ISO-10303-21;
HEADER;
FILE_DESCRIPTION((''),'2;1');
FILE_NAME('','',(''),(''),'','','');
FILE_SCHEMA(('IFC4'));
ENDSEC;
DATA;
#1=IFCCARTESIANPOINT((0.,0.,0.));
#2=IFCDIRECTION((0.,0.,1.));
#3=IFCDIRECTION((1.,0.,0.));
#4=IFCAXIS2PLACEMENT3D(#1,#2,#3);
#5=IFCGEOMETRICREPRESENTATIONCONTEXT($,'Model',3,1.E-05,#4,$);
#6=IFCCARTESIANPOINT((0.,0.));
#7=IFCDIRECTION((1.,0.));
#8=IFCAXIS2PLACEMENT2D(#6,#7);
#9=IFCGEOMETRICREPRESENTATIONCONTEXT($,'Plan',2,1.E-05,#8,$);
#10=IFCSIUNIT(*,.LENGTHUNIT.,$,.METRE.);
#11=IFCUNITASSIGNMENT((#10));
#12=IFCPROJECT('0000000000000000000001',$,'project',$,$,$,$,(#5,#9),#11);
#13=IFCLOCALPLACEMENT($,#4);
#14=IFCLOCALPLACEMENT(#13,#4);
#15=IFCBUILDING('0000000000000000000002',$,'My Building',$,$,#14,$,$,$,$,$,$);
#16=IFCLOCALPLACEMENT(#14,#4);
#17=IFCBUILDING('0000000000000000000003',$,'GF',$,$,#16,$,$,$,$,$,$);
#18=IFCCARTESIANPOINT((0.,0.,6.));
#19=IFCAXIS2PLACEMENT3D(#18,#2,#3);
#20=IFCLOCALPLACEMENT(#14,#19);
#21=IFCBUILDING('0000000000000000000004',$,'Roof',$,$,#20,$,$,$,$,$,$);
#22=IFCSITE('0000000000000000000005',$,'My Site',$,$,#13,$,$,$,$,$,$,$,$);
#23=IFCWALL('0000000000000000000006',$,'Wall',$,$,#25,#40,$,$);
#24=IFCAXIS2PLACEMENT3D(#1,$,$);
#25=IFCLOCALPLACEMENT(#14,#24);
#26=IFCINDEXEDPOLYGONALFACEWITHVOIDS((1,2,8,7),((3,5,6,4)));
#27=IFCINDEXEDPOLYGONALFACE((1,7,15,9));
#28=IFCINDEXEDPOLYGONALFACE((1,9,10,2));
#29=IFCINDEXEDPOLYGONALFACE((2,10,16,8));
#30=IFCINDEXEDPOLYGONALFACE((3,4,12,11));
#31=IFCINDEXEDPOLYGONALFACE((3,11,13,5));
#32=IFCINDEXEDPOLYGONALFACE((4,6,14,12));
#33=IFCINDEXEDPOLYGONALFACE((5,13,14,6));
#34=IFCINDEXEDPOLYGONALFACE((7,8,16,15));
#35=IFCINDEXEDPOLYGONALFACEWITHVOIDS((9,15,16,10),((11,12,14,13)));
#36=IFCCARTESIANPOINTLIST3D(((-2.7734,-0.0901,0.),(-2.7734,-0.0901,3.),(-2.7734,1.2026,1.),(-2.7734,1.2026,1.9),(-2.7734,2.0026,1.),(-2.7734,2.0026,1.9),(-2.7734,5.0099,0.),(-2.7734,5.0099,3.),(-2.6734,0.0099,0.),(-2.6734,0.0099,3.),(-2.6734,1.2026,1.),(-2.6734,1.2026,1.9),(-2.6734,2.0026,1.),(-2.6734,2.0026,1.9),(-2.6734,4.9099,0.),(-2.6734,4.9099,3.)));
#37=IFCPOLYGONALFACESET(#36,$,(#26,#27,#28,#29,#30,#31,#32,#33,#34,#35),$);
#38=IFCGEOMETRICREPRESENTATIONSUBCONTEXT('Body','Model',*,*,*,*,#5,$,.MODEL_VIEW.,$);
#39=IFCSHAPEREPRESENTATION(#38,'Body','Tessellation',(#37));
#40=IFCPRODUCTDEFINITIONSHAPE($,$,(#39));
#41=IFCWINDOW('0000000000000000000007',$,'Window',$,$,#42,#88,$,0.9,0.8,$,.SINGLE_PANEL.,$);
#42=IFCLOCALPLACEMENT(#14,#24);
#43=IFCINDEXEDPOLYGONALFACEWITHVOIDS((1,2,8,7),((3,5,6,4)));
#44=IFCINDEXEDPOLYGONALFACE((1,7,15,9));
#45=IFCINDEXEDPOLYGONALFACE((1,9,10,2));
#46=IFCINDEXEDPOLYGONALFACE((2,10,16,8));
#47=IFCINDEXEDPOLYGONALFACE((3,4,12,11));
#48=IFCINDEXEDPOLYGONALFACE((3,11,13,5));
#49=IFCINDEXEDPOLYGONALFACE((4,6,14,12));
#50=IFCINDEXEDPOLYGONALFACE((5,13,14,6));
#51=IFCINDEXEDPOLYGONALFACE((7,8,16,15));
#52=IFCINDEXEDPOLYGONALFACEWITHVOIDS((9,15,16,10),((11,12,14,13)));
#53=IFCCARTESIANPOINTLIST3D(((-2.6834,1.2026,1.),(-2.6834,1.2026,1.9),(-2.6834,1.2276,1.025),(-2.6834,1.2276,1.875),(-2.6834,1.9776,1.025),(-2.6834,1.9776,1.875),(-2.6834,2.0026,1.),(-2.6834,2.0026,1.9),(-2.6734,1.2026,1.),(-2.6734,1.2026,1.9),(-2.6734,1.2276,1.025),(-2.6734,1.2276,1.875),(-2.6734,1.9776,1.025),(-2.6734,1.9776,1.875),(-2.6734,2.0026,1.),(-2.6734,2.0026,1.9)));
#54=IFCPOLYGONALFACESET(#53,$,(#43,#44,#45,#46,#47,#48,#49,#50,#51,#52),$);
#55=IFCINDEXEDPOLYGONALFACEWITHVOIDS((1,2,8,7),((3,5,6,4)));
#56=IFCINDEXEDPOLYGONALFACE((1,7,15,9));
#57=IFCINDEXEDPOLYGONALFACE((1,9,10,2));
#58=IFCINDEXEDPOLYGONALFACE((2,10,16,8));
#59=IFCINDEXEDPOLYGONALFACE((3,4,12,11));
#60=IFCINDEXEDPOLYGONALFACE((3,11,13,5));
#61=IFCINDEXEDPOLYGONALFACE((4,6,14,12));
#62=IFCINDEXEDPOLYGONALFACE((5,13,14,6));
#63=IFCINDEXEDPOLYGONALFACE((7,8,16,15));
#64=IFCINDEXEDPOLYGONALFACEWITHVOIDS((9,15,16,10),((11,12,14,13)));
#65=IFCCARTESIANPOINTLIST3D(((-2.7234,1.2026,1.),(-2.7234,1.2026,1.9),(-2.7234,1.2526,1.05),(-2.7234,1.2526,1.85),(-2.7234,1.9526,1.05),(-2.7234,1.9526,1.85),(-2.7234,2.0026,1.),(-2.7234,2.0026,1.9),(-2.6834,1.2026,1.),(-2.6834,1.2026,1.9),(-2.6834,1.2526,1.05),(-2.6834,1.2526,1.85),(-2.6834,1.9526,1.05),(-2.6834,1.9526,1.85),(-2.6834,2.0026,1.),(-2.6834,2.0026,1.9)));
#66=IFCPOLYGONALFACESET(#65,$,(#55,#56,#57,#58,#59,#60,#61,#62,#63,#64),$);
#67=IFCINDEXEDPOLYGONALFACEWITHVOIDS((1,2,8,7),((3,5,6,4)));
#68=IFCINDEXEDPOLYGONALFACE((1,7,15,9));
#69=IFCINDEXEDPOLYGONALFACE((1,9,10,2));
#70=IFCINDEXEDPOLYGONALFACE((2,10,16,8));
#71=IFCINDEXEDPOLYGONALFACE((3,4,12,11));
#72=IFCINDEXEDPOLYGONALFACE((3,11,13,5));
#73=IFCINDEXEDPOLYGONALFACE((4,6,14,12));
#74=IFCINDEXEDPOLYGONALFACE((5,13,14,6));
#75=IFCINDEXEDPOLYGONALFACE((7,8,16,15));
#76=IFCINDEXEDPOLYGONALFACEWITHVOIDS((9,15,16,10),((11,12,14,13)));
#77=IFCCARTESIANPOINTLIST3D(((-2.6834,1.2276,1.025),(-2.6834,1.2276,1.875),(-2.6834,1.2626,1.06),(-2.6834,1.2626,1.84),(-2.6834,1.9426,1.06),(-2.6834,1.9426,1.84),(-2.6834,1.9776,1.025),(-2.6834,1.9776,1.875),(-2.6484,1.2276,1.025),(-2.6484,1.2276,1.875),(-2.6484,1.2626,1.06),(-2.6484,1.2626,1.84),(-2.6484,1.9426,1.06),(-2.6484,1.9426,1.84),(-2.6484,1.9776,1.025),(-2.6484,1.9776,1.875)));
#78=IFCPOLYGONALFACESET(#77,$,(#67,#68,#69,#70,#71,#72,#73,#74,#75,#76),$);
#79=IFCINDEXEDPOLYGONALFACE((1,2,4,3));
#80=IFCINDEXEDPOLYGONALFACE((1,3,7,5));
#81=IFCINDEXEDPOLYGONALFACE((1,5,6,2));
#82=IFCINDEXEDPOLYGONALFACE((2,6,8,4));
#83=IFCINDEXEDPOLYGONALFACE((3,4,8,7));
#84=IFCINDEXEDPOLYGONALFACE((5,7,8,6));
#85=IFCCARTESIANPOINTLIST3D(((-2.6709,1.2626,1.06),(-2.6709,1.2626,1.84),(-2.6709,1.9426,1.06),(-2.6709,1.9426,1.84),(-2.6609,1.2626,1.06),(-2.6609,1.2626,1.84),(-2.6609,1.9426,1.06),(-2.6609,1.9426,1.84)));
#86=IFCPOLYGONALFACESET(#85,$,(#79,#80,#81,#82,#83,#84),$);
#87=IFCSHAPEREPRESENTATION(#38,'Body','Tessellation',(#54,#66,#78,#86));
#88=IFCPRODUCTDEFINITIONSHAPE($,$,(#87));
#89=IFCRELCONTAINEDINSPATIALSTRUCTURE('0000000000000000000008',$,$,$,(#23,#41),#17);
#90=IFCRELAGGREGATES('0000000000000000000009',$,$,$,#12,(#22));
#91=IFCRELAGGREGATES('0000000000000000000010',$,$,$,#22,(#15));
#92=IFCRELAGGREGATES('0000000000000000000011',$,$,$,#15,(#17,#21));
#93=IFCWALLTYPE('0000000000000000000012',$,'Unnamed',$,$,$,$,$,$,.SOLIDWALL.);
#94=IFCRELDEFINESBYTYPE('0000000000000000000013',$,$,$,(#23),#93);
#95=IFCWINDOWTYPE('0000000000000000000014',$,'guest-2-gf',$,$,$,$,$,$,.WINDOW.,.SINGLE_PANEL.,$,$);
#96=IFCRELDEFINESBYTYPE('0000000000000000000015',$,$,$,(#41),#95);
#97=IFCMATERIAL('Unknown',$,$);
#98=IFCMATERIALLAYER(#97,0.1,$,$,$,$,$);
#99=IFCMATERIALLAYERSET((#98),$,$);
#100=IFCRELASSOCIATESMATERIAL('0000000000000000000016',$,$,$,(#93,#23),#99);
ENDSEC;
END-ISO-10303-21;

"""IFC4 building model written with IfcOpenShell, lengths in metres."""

from ifc_helpers import new_model, entity, si_unit, frame, origin_with_axes, origin_2d_with_axis, place, context, subcontext, project, spatial, line, indexed_curve, outline, extrude, shape, source, transform, mapped, material, layer, layer_set, layer_usage, type_object, type_shapes, element, fill, save


model = new_model("IFC4")

# Units and contexts
model_context = context("Model", 3, precision=1e-05, world=origin_with_axes())
plan_context = context("Plan", 2, precision=1e-05, world=origin_2d_with_axis())
body_context_1 = subcontext(model_context, "Body", "Model", "MODEL_VIEW")
body_context_2 = subcontext(plan_context, "Body", "Plan", "PLAN_VIEW")
ifc_project = project(units=[si_unit("LENGTHUNIT", "METRE")], contexts=[model_context, plan_context])

# Site, buildings
site_placement = place(None, origin_with_axes())
site = spatial("IfcSite", under=ifc_project, at=site_placement, Name="My Site")
building_1_placement = place(site_placement, origin_with_axes())
building_1 = spatial("IfcBuilding", under=site, at=building_1_placement, Name="My Building")
building_2_placement = place(building_1_placement, origin_with_axes())
building_2 = spatial("IfcBuilding", under=building_1, at=building_2_placement, Name="GF")

# Shared definitions
ifc_material = material(Name="Unknown")

# Shared definitions
building_3_placement = place(building_1_placement, frame((0.0, 0.0, 6.0), z_axis=(0.0, 0.0, 1.0), x_axis=(1.0, 0.0, 0.0)))
building_3 = spatial("IfcBuilding", under=building_1, at=building_3_placement, Name="Roof")

# Shared definitions
ifc_layer_1 = layer(ifc_material, 0.1)
ifc_layer_set_1 = layer_set([ifc_layer_1])
wall_type = type_object("IfcWallType", Name="Unnamed", PredefinedType="SOLIDWALL", material=ifc_layer_set_1)

# Wall, opening, window
ifc_layer_usage_1 = layer_usage(ifc_layer_set_1, "AXIS2", "POSITIVE", 0.0)
wall_1_placement = place(building_2_placement, frame((-2.7734, 5.0099, 0.0), z_axis=(0.0, 0.0, 1.0), x_axis=(0.0, -1.0, 0.0)))
wall_1 = element("IfcWall", 1, at=wall_1_placement, inside=building_2, type_object=wall_type, material=ifc_layer_usage_1, Name="Wall", context=body_context_1, shape_type="SweptSolid", body=[
    extrude(outline(indexed_curve([(0.0, 0.0), (0.1, 0.1), (5.0, 0.1), (5.1, 0.0)], segments=[line(1, 2, 3, 4, 1)])), origin_with_axes(), (0.0, 0.0, 1.0), 3.0),
])
shared_shape_1 = source(origin_with_axes(), body_context_1, "Body", "SweptSolid", [
    extrude(outline(indexed_curve([(0.0, 0.0), (0.8, 0.0), (0.8, 0.9), (0.0, 0.9)], segments=[line(1, 2, 3, 4, 1)])), frame((0.0, -0.6, 0.0), z_axis=(0.0, -1.0, 0.0), x_axis=(1.0, 0.0, 0.0)), (0.0, 0.0, -1.0), 1.2),
])
opening_1_placement = place(wall_1_placement, frame((3.0073, 0.0, 1.0), z_axis=(0.0, 0.0, 1.0), x_axis=(1.0, 0.0, 0.0)))
opening_1 = element("IfcOpeningElement", 2, at=opening_1_placement, cuts=wall_1, PredefinedType="OPENING", context=body_context_1, shape_type="MappedRepresentation", body=[
    mapped(shared_shape_1, transform((0.0, 0.0, 0.0), x_axis=(1.0, 0.0, 0.0), y_axis=(0.0, 1.0, 0.0), z_axis=(0.0, 0.0, 1.0), scale=1.0)),
])
window_type_1 = type_object("IfcWindowType", Name="guest-2-gf", PartitioningType="SINGLE_PANEL", PredefinedType="WINDOW")
shared_shape_2 = source(origin_with_axes(), body_context_1, "Body", "SweptSolid", [
    extrude(outline(indexed_curve([(0.0, 0.0), (0.8, 0.0), (0.8, 0.9), (0.0, 0.9)], segments=[line(1, 2, 3, 4, 1)]), holes=[indexed_curve([(0.025, 0.025), (0.775, 0.025), (0.775, 0.875), (0.025, 0.875)], segments=[line(1, 2, 3, 4, 1)])]), frame((0.0, 0.09, 0.0), z_axis=(0.0, -1.0, 0.0), x_axis=(1.0, 0.0, 0.0)), (0.0, 0.0, -1.0), 0.01),
    extrude(outline(indexed_curve([(0.0, 0.0), (0.8, 0.0), (0.8, 0.9), (0.0, 0.9)], segments=[line(1, 2, 3, 4, 1)]), holes=[indexed_curve([(0.05, 0.05), (0.75, 0.05), (0.75, 0.85), (0.05, 0.85)], segments=[line(1, 2, 3, 4, 1)])]), frame((0.0, 0.05, 0.0), z_axis=(0.0, -1.0, 0.0), x_axis=(1.0, 0.0, 0.0)), (0.0, 0.0, -1.0), 0.04),
    extrude(outline(indexed_curve([(0.0, 0.0), (0.75, 0.0), (0.75, 0.85), (0.0, 0.85)], segments=[line(1, 2, 3, 4, 1)]), holes=[indexed_curve([(0.035, 0.035), (0.715, 0.035), (0.715, 0.815), (0.035, 0.815)], segments=[line(1, 2, 3, 4, 1)])]), frame((0.025, 0.09, 0.025), z_axis=(0.0, -1.0, 0.0), x_axis=(1.0, 0.0, 0.0)), (0.0, 0.0, -1.0), 0.035),
    extrude(outline(indexed_curve([(0.035, 0.035), (0.715, 0.035), (0.715, 0.815), (0.035, 0.815)], segments=[line(1, 2, 3, 4, 1)])), frame((0.025, 0.1025, 0.025), z_axis=(0.0, -1.0, 0.0), x_axis=(1.0, 0.0, 0.0)), (0.0, 0.0, -1.0), 0.01),
])
shared_shape_3 = source(origin_with_axes(), body_context_2, "Body", "Curve2D", [
    entity("IfcIndexedPolyCurve", entity("IfcCartesianPointList2D", [[0.05, 0.05], [0.75, 0.05]])),
    entity("IfcIndexedPolyCurve", entity("IfcCartesianPointList2D", [[0.0, 0.1], [0.025, 0.1], [0.025, 0.09], [0.05, 0.09], [0.05, 0.05], [0.0, 0.05]]), [entity("IfcLineIndex", [1, 2, 3, 4, 5, 6, 1])]),
    entity("IfcIndexedPolyCurve", entity("IfcCartesianPointList2D", [[0.8, 0.1], [0.775, 0.1], [0.775, 0.09], [0.75, 0.09], [0.75, 0.05], [0.8, 0.05]]), [entity("IfcLineIndex", [1, 2, 3, 4, 5, 6, 1])]),
    entity("IfcIndexedPolyCurve", entity("IfcCartesianPointList2D", [[0.025, 0.09], [0.06, 0.09], [0.06, 0.125], [0.025, 0.125]]), [entity("IfcLineIndex", [1, 2, 3, 4, 1])]),
    entity("IfcIndexedPolyCurve", entity("IfcCartesianPointList2D", [[0.775, 0.09], [0.74, 0.09], [0.74, 0.125], [0.775, 0.125]]), [entity("IfcLineIndex", [1, 2, 3, 4, 1])]),
    entity("IfcIndexedPolyCurve", entity("IfcCartesianPointList2D", [[0.06, 0.09], [0.74, 0.09]])),
    entity("IfcIndexedPolyCurve", entity("IfcCartesianPointList2D", [[0.06, 0.125], [0.74, 0.125]])),
    entity("IfcIndexedPolyCurve", entity("IfcCartesianPointList2D", [[0.06, 0.1075], [0.74, 0.1075]])),
])
type_shapes(window_type_1, [shared_shape_2, shared_shape_3])
window_1_placement = place(opening_1_placement, frame((0.0, 0.0, 0.0), z_axis=(0.0, 0.0, 1.0), x_axis=(1.0, 0.0, 0.0)))
window_1 = element("IfcWindow", 3, at=window_1_placement, inside=building_2, type_object=window_type_1, Name="Window", OverallHeight=0.9, OverallWidth=0.8, PartitioningType="SINGLE_PANEL", shapes=[
    shape(body_context_1, "Body", "MappedRepresentation", [mapped(shared_shape_2, transform((0.0, 0.0, 0.0), x_axis=(1.0, 0.0, 0.0), y_axis=(0.0, 1.0, 0.0), z_axis=(0.0, 0.0, 1.0), scale=1.0))]),
    shape(body_context_2, "Body", "MappedRepresentation", [mapped(shared_shape_3, transform((0.0, 0.0, 0.0), x_axis=(1.0, 0.0, 0.0), y_axis=(0.0, 1.0, 0.0), z_axis=(0.0, 0.0, 1.0), scale=1.0))]),
])
fill(opening_1, window_1)

save(model, "model.ifc")
